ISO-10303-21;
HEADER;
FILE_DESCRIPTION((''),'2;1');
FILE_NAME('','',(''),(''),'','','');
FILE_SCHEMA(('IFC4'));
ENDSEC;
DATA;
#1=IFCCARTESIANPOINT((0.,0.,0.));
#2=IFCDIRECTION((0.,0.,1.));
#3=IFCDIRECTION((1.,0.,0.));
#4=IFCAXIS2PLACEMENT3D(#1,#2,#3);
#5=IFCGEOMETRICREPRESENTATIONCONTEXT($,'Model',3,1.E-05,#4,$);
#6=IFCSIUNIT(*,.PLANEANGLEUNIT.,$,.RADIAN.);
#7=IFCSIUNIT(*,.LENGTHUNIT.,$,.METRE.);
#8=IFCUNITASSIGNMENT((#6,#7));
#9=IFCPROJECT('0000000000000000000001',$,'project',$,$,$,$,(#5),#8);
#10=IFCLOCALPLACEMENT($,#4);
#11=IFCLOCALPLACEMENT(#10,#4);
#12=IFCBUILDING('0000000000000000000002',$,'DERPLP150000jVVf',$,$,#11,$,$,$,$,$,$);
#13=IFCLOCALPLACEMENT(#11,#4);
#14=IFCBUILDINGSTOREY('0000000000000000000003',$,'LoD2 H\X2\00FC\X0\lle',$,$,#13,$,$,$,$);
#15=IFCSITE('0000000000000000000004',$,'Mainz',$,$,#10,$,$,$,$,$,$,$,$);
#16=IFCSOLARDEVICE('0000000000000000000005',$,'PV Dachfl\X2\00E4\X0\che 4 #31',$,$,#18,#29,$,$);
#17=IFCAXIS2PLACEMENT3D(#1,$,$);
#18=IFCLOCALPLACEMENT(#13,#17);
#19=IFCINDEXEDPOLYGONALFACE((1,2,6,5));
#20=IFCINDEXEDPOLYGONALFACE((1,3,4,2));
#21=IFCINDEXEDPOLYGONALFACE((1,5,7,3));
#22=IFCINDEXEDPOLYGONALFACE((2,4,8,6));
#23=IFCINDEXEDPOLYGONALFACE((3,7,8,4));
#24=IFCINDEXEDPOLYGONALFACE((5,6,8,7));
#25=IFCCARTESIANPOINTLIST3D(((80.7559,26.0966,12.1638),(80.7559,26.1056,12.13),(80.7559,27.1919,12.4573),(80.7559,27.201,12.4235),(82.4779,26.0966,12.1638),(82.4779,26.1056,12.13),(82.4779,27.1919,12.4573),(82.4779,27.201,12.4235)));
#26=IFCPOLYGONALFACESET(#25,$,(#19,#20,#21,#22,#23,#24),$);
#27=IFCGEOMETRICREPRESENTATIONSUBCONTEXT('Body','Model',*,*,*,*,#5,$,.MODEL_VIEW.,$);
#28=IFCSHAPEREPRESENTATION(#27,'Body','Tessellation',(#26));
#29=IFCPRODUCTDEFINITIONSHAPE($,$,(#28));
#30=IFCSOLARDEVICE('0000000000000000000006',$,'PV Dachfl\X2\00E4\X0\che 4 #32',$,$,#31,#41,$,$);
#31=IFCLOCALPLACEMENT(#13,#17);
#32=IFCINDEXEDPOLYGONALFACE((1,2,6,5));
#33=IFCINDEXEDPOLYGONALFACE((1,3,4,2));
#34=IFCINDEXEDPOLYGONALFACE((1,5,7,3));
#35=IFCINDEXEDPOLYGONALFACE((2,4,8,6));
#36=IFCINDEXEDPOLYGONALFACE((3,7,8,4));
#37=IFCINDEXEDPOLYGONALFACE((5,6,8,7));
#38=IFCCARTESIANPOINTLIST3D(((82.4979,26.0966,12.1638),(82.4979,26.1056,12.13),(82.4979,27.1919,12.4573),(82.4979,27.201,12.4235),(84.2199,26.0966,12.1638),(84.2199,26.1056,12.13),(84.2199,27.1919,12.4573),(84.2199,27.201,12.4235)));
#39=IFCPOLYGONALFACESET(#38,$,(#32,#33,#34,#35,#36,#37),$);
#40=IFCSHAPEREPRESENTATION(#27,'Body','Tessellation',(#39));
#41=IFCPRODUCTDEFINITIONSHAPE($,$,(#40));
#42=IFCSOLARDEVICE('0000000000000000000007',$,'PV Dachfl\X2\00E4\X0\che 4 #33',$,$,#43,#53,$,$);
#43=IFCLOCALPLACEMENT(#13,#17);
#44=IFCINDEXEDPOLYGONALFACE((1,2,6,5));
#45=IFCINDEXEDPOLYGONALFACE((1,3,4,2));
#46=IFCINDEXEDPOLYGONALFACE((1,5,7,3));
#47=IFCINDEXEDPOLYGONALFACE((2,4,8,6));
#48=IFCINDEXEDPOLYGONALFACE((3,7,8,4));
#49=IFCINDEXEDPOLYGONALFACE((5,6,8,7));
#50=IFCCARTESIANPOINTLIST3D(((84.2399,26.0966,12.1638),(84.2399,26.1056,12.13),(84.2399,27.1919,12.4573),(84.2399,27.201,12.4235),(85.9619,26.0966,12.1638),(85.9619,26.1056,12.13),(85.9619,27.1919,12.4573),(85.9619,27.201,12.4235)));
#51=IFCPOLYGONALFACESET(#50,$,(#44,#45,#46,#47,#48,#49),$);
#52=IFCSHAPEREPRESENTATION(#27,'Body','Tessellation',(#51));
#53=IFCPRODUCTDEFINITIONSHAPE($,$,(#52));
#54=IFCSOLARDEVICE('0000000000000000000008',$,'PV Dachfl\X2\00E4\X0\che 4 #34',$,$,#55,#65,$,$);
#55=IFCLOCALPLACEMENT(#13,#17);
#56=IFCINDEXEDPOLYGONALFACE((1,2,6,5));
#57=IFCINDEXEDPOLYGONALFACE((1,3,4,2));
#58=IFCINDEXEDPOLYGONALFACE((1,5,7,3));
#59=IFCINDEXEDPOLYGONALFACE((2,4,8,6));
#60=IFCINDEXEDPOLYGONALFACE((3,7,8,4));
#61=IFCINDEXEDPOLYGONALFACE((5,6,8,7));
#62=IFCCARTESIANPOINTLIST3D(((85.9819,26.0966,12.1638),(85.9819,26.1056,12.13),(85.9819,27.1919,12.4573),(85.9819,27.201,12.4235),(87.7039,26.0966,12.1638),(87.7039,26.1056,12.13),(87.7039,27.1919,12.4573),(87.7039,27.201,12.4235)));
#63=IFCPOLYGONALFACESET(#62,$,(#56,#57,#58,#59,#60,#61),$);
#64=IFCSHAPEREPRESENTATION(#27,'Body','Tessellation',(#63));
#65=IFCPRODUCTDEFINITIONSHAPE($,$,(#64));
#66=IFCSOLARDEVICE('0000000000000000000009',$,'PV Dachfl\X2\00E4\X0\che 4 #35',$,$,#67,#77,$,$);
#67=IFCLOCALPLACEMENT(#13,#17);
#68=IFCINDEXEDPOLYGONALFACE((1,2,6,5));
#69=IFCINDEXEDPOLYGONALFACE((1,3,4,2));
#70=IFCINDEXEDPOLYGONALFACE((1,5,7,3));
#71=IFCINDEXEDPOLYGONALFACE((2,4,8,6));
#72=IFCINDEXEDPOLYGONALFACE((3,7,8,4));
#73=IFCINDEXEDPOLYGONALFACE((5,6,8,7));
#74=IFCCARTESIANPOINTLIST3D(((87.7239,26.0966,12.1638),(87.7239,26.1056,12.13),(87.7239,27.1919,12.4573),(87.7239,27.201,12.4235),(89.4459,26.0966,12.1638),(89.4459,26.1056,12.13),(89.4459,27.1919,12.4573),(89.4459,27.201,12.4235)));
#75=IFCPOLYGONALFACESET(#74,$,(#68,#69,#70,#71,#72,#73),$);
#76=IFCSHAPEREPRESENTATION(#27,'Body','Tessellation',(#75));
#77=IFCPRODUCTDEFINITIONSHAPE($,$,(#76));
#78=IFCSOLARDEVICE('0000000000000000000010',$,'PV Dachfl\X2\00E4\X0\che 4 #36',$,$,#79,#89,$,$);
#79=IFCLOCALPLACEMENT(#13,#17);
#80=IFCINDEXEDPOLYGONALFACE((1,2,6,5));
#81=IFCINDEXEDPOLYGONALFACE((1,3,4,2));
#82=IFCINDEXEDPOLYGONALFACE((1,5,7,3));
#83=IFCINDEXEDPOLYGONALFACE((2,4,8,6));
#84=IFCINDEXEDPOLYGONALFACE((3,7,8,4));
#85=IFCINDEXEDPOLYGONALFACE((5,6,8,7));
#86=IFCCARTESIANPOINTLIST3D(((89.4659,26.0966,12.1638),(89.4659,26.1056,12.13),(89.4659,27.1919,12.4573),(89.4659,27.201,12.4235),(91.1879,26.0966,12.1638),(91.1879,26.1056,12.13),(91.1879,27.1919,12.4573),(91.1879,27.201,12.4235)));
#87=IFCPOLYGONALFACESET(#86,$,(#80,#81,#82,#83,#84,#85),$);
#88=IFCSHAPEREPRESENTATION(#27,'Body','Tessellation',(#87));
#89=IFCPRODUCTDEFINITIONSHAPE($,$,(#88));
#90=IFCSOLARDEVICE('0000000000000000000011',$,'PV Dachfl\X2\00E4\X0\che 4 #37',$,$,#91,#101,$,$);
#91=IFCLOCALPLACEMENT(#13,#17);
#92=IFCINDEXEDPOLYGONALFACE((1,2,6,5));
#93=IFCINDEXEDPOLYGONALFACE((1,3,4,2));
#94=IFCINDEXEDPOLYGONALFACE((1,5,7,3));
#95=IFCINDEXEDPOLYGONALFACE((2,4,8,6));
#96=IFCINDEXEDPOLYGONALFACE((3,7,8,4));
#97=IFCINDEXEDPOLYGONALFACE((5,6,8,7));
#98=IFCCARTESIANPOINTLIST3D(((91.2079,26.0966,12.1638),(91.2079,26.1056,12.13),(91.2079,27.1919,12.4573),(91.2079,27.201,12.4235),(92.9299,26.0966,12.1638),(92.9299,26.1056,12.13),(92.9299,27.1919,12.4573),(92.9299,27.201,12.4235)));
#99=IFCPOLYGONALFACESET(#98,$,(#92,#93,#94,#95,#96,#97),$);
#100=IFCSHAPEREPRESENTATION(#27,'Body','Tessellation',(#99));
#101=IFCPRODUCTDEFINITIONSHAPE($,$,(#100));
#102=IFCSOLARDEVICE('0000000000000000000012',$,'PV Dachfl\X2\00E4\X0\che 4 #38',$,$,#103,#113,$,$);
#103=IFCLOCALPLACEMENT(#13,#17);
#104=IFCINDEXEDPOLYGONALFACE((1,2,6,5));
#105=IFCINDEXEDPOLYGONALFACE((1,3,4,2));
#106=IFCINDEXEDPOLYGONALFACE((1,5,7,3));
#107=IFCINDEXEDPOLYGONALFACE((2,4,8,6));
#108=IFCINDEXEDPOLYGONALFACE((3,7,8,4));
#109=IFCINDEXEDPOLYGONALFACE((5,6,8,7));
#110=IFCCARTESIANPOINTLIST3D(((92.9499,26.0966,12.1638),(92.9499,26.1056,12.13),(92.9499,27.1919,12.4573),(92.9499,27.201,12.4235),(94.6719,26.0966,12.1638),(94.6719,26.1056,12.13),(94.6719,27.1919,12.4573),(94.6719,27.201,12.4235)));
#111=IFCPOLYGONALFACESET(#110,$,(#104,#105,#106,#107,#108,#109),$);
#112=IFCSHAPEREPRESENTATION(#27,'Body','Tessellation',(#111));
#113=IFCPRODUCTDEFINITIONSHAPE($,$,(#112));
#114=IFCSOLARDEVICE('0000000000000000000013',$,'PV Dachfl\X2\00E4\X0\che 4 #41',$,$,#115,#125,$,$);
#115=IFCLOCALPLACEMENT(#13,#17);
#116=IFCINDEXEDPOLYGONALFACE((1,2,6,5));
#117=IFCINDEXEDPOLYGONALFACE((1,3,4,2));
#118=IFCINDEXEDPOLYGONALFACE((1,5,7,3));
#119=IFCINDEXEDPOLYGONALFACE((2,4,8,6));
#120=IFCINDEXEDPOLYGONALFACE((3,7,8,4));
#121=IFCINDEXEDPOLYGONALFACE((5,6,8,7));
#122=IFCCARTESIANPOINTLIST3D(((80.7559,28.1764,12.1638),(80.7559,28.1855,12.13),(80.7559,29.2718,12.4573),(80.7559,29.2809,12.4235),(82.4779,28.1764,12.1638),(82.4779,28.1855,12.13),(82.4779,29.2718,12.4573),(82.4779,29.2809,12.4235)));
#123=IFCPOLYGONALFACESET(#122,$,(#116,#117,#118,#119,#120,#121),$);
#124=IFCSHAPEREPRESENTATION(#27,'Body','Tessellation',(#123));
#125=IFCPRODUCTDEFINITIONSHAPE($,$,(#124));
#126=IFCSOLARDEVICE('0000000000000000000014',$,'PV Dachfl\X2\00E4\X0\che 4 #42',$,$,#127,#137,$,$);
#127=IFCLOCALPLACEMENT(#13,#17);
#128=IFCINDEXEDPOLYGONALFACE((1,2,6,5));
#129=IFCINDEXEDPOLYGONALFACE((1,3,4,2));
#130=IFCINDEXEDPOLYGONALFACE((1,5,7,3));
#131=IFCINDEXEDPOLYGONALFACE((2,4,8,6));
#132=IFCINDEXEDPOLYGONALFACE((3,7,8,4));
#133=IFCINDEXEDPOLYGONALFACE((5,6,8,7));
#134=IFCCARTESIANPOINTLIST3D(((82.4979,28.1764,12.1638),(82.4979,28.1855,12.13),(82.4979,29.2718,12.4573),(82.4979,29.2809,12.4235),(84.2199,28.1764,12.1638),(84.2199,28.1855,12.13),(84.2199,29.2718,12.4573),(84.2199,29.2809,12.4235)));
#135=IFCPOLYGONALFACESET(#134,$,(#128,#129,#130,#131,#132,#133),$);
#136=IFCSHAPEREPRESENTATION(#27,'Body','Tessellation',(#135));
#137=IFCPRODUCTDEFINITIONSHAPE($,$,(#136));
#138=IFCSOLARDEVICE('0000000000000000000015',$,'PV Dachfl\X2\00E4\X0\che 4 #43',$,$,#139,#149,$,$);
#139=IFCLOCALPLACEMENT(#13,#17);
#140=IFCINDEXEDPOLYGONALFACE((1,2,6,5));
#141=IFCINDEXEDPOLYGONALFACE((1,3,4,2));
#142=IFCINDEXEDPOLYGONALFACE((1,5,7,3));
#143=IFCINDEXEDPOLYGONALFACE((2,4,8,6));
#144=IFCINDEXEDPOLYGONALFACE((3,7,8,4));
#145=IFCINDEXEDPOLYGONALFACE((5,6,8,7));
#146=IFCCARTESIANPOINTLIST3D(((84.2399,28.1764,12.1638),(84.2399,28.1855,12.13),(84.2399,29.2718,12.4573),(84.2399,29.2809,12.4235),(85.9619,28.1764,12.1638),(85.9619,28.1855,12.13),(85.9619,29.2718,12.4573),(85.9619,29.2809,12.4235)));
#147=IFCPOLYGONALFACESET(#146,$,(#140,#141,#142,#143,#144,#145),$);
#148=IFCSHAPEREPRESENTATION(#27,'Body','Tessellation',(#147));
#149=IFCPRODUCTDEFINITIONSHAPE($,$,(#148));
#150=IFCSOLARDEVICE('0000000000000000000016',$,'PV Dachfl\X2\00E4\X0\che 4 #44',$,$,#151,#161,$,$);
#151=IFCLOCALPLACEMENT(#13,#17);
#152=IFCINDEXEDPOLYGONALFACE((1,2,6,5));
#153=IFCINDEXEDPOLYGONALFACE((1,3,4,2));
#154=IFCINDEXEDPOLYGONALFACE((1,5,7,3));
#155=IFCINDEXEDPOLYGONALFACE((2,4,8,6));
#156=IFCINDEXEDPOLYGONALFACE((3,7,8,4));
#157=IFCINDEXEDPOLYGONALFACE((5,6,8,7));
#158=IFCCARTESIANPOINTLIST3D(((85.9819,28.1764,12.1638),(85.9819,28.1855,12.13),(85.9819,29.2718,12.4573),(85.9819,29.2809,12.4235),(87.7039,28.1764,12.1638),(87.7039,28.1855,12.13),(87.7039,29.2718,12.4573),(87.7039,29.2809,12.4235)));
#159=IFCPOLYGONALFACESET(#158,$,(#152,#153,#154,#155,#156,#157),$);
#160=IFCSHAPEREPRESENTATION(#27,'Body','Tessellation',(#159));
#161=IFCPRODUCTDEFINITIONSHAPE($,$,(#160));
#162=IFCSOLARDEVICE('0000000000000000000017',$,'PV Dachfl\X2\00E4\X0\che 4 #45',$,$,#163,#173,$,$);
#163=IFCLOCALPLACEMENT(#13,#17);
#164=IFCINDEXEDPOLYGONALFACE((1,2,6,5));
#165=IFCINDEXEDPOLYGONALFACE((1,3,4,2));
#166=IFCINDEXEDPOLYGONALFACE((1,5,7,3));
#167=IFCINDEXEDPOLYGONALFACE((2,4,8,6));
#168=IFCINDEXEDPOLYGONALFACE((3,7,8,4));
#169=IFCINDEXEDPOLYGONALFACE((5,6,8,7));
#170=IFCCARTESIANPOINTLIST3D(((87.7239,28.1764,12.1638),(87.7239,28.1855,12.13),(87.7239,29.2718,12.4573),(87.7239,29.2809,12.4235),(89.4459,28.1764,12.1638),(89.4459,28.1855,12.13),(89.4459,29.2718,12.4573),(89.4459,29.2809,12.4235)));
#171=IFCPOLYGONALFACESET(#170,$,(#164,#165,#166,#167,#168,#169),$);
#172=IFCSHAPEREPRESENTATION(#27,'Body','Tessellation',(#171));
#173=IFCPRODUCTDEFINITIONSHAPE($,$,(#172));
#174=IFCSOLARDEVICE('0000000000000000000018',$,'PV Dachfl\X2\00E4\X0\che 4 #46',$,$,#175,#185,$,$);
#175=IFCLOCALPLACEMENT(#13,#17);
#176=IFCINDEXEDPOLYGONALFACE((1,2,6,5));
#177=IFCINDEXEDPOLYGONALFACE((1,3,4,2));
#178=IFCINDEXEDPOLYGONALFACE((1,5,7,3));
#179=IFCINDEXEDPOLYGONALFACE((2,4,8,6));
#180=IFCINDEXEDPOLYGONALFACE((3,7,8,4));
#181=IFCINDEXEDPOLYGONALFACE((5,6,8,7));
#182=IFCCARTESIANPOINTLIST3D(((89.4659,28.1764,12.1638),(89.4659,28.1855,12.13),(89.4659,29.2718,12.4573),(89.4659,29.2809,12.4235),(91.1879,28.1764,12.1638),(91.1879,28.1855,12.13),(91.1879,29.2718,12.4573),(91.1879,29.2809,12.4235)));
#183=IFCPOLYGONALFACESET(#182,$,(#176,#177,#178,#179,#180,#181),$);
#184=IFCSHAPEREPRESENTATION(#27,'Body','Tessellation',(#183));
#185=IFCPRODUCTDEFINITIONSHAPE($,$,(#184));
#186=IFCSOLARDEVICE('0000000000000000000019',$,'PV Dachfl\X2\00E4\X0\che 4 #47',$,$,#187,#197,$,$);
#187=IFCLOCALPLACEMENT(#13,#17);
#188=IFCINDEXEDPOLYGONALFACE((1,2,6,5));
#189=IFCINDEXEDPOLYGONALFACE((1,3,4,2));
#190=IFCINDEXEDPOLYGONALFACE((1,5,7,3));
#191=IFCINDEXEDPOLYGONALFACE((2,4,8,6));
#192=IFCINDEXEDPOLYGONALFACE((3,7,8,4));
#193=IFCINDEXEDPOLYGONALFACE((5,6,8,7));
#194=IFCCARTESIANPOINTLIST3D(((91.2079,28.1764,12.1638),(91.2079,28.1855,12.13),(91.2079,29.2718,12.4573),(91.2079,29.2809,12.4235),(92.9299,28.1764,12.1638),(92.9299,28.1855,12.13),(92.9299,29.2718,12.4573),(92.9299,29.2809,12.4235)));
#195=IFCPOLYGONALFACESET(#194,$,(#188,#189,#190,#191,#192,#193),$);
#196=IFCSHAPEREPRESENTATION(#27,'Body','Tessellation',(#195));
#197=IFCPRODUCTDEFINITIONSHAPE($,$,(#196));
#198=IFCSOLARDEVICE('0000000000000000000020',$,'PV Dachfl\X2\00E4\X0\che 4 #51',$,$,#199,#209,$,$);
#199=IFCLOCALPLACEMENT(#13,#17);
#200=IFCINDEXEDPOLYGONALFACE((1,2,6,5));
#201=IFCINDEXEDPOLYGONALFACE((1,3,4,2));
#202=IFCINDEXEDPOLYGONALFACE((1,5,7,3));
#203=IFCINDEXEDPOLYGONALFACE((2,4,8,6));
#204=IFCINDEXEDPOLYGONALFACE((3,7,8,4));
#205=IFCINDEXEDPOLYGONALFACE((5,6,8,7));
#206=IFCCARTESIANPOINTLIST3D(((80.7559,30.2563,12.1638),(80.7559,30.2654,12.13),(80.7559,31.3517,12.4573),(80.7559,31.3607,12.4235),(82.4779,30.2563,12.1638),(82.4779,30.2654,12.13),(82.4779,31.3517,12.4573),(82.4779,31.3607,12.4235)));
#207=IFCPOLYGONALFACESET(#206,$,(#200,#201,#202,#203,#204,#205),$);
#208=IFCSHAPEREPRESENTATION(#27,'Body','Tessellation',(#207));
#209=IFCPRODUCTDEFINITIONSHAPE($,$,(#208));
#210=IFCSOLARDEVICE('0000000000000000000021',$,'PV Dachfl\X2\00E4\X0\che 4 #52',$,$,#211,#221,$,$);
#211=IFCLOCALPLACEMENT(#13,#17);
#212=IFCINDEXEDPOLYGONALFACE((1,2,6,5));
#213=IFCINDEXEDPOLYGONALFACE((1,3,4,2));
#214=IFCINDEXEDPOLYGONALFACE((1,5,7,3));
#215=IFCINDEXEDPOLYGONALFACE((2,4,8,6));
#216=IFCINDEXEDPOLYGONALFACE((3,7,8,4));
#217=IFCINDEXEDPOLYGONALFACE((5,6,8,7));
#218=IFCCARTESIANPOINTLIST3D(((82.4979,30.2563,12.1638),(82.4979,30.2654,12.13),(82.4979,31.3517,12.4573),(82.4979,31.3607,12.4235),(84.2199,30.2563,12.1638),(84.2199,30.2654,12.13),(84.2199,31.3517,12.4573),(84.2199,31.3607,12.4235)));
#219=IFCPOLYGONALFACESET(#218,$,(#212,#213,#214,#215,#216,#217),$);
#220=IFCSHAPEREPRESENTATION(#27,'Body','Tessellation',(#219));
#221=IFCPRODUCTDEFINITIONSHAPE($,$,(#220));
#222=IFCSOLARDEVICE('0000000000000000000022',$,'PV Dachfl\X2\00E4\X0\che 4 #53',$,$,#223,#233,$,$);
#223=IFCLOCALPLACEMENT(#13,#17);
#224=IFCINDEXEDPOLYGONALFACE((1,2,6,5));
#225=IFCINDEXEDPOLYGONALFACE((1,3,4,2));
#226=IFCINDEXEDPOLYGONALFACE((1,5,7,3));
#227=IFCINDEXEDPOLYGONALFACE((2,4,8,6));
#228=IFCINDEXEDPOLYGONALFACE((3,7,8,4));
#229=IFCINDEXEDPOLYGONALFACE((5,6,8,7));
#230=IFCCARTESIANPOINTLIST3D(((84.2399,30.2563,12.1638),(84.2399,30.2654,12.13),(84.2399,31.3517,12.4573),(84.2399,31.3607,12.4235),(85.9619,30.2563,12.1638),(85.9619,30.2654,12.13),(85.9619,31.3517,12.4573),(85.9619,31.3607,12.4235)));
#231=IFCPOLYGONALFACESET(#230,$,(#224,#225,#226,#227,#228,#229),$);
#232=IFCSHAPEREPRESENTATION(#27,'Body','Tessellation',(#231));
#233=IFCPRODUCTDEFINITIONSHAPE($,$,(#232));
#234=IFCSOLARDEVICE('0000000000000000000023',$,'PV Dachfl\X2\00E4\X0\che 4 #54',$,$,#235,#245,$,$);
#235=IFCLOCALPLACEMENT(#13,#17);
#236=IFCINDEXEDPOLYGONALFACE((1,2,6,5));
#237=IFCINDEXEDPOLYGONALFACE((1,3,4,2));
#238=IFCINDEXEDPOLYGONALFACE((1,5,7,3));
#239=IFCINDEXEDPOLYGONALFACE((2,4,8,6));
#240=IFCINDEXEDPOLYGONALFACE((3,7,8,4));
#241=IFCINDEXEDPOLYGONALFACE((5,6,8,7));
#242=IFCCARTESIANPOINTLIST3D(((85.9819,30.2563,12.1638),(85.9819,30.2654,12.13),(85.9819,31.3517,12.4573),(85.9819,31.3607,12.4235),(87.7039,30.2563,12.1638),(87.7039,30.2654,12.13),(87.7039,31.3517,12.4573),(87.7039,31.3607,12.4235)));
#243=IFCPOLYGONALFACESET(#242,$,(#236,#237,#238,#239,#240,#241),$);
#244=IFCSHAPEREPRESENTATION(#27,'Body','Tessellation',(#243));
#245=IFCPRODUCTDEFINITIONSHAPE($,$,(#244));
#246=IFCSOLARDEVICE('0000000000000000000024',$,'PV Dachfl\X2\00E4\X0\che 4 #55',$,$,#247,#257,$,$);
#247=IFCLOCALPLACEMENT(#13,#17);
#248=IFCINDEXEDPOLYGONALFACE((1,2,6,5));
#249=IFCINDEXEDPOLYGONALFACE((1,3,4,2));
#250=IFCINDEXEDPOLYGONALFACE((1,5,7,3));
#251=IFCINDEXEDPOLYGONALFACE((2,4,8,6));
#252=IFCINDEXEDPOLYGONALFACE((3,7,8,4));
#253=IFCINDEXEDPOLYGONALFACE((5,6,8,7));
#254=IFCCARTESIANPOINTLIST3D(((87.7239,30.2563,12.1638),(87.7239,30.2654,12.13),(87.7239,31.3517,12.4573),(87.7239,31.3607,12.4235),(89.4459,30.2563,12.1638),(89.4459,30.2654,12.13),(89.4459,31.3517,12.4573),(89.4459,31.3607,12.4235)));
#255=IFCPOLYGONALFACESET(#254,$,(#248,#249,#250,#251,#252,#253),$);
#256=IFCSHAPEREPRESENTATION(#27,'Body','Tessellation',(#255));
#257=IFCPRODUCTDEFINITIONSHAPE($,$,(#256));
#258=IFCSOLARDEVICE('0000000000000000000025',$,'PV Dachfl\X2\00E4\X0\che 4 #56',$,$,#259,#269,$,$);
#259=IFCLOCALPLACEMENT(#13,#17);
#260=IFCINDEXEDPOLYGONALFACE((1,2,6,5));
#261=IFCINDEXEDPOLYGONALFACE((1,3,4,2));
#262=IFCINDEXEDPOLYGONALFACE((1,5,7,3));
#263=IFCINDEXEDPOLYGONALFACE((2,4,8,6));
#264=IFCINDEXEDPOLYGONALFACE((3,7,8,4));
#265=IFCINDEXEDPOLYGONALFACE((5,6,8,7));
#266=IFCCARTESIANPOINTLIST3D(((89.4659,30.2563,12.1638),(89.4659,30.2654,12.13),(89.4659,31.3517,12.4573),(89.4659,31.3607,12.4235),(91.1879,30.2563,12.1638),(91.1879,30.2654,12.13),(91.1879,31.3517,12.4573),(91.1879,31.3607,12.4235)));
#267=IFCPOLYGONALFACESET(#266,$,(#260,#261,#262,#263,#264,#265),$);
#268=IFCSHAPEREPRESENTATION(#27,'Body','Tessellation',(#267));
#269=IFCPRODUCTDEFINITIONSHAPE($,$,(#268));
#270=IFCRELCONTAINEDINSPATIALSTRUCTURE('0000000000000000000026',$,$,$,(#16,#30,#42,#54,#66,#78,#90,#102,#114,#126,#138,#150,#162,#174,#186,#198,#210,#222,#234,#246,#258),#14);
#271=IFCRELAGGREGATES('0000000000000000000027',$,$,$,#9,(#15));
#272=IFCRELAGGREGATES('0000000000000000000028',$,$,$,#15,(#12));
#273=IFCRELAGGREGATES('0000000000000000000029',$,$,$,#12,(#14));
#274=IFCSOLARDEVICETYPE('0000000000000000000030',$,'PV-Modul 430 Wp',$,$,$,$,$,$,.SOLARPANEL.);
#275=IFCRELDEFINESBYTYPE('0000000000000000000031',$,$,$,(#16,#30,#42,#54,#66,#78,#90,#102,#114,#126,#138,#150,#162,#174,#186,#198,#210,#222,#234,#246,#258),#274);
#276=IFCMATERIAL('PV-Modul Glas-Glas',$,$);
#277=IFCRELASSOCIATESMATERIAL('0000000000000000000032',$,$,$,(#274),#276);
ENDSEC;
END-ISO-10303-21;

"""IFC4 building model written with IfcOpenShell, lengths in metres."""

from ifc_helpers import new_model, si_unit, frame, frame_2d, origin, origin_with_axes, place, context, subcontext, project, spatial, rectangle, extrude, source, transform, mapped, material, type_object, type_shapes, element, save


model = new_model("IFC4")

# Units and contexts
model_context = context("Model", 3, precision=1e-05, world=origin_with_axes())
body_context = subcontext(model_context, "Body", "Model", "MODEL_VIEW")
ifc_project = project(units=[si_unit("PLANEANGLEUNIT", "RADIAN"), si_unit("LENGTHUNIT", "METRE")], contexts=[model_context])

# Site, building, storey
site_placement = place(None, origin_with_axes())
site = spatial("IfcSite", under=ifc_project, at=site_placement, Name="Mainz")
building_placement = place(site_placement, origin_with_axes())
building = spatial("IfcBuilding", under=site, at=building_placement, Name="DERPLP150000jVVf")
storey_placement = place(building_placement, origin_with_axes())
storey = spatial("IfcBuildingStorey", under=building, at=storey_placement, Name="LoD2 Hülle")

# Solar devices
ifc_material = material(Name="PV-Modul Glas-Glas")
solar_device_type = type_object("IfcSolarDeviceType", Name="PV-Modul 430 Wp", PredefinedType="SOLARPANEL", material=ifc_material)
shared_shape = source(origin_with_axes(), body_context, "Body", "SweptSolid", [
    extrude(rectangle(XDim=1.722, YDim=1.134, at=frame_2d((0.861, 0.567))), origin(), (0.0, 0.0, 1.0), 0.035),
])
type_shapes(solar_device_type, [shared_shape])
for number, where, z_axis, x_axis, name in (
    (1, (80.7559, 26.1056, 12.13), (0.0, -0.258819, 0.965926), (1.0, 0.0, 0.0), "PV Dachfläche 4 #31"),
    (2, (82.4979, 26.1056, 12.13), (0.0, -0.258819, 0.965926), (1.0, 0.0, 0.0), "PV Dachfläche 4 #32"),
    (3, (84.2399, 26.1056, 12.13), (0.0, -0.258819, 0.965926), (1.0, 0.0, 0.0), "PV Dachfläche 4 #33"),
    (4, (85.9819, 26.1056, 12.13), (0.0, -0.258819, 0.965926), (1.0, 0.0, 0.0), "PV Dachfläche 4 #34"),
    (5, (87.7239, 26.1056, 12.13), (0.0, -0.258819, 0.965926), (1.0, 0.0, 0.0), "PV Dachfläche 4 #35"),
    (6, (89.4659, 26.1056, 12.13), (0.0, -0.258819, 0.965926), (1.0, 0.0, 0.0), "PV Dachfläche 4 #36"),
    (7, (91.2079, 26.1056, 12.13), (0.0, -0.258819, 0.965926), (1.0, 0.0, 0.0), "PV Dachfläche 4 #37"),
    (8, (92.9499, 26.1056, 12.13), (0.0, -0.258819, 0.965926), (1.0, 0.0, 0.0), "PV Dachfläche 4 #38"),
    (9, (80.7559, 28.1855, 12.13), (0.0, -0.258819, 0.965926), (1.0, 0.0, 0.0), "PV Dachfläche 4 #41"),
    (10, (82.4979, 28.1855, 12.13), (0.0, -0.258819, 0.965926), (1.0, 0.0, 0.0), "PV Dachfläche 4 #42"),
    (11, (84.2399, 28.1855, 12.13), (0.0, -0.258819, 0.965926), (1.0, 0.0, 0.0), "PV Dachfläche 4 #43"),
    (12, (85.9819, 28.1855, 12.13), (0.0, -0.258819, 0.965926), (1.0, 0.0, 0.0), "PV Dachfläche 4 #44"),
    (13, (87.7239, 28.1855, 12.13), (0.0, -0.258819, 0.965926), (1.0, 0.0, 0.0), "PV Dachfläche 4 #45"),
    (14, (89.4659, 28.1855, 12.13), (0.0, -0.258819, 0.965926), (1.0, 0.0, 0.0), "PV Dachfläche 4 #46"),
    (15, (91.2079, 28.1855, 12.13), (0.0, -0.258819, 0.965926), (1.0, 0.0, 0.0), "PV Dachfläche 4 #47"),
    (16, (80.7559, 30.2654, 12.13), (0.0, -0.258819, 0.965926), (1.0, 0.0, 0.0), "PV Dachfläche 4 #51"),
    (17, (82.4979, 30.2654, 12.13), (0.0, -0.258819, 0.965926), (1.0, 0.0, 0.0), "PV Dachfläche 4 #52"),
    (18, (84.2399, 30.2654, 12.13), (0.0, -0.258819, 0.965926), (1.0, 0.0, 0.0), "PV Dachfläche 4 #53"),
    (19, (85.9819, 30.2654, 12.13), (0.0, -0.258819, 0.965926), (1.0, 0.0, 0.0), "PV Dachfläche 4 #54"),
    (20, (87.7239, 30.2654, 12.13), (0.0, -0.258819, 0.965926), (1.0, 0.0, 0.0), "PV Dachfläche 4 #55"),
    (21, (89.4659, 30.2654, 12.13), (0.0, -0.258819, 0.965926), (1.0, 0.0, 0.0), "PV Dachfläche 4 #56"),
):
    element("IfcSolarDevice", number, at=place(storey_placement, frame(where, z_axis=z_axis, x_axis=x_axis)), inside=storey, type_object=solar_device_type, Name=name, context=body_context, shape_type="MappedRepresentation", body=[
        mapped(shared_shape, transform((0.0, 0.0, 0.0), x_axis=(1.0, 0.0, 0.0), y_axis=(0.0, 1.0, 0.0), z_axis=(0.0, 0.0, 1.0), scale=1.0)),
    ])

save(model, "model.ifc")
